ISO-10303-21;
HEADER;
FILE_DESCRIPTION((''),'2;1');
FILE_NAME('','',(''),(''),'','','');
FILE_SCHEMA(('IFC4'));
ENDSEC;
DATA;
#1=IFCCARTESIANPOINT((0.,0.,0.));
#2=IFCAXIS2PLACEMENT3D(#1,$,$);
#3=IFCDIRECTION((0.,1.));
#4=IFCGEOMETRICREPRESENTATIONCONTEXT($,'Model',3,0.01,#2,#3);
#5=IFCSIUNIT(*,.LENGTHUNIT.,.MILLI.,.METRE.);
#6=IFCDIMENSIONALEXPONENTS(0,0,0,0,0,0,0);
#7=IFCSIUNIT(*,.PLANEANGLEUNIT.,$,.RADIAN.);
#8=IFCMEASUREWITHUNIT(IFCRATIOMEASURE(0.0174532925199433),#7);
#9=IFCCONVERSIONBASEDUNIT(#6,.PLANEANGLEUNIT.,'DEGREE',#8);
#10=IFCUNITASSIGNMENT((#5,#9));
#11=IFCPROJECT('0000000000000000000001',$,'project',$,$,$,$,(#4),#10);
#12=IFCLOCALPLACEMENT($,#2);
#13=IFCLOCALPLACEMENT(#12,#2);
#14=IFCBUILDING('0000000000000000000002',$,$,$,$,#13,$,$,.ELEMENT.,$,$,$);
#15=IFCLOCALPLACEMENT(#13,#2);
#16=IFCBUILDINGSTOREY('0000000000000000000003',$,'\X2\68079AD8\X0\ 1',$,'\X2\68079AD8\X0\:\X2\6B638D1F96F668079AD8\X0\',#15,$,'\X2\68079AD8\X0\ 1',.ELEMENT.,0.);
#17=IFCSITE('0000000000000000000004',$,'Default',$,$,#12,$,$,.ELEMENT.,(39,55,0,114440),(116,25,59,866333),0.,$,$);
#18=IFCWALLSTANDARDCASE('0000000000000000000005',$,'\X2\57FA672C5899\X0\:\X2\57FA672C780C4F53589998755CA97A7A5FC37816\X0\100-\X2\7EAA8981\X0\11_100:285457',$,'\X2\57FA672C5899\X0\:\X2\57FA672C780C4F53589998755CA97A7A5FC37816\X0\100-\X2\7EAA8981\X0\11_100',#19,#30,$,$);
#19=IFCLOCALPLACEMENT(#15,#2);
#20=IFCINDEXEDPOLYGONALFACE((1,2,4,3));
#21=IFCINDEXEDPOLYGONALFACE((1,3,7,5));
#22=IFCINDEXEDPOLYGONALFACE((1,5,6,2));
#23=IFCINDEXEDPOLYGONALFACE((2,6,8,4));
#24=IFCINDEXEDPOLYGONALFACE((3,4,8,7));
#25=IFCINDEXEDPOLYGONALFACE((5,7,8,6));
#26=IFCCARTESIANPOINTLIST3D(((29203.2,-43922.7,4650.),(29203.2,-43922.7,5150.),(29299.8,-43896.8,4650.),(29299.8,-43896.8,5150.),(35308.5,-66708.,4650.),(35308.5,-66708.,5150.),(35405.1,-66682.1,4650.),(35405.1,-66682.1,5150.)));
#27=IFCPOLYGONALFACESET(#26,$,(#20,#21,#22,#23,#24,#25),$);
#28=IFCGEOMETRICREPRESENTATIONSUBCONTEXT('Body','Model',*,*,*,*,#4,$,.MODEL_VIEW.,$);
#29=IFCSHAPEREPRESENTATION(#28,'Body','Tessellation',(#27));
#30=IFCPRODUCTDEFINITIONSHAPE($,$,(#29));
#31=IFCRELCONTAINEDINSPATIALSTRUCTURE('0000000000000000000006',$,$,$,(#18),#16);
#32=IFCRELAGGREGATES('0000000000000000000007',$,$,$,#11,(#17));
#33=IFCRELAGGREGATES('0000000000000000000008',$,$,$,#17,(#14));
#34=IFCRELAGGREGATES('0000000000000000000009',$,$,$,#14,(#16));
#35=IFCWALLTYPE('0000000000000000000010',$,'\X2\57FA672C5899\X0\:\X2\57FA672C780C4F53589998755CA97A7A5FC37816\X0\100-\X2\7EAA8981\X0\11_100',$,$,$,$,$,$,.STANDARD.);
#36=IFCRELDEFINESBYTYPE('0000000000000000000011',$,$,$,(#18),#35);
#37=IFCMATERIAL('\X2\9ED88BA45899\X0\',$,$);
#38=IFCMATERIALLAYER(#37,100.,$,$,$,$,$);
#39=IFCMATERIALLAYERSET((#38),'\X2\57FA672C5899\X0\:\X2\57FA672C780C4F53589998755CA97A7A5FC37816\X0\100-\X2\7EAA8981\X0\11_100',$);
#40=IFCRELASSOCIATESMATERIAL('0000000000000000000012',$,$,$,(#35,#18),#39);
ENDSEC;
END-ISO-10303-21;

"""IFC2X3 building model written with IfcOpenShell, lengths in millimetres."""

from ifc_helpers import new_model, entity, si_unit, converted_unit, direction, frame, frame_2d, origin, place, context, subcontext, project, spatial, rectangle, extrude, material, layer, layer_set, layer_usage, type_object, element, save


model = new_model("IFC2X3")

# Units and contexts
model_context = context("Model", 3, precision=0.01, world=origin(), true_north=direction((0.0, 1.0)))
body_context = subcontext(model_context, "Body", "Model", "MODEL_VIEW")
ifc_project = project(units=[si_unit("LENGTHUNIT", "METRE", prefix="MILLI"), converted_unit("PLANEANGLEUNIT", "DEGREE", entity("IfcRatioMeasure", 0.0174532925199433), si_unit("PLANEANGLEUNIT", "RADIAN"), dimensions=[0, 0, 0, 0, 0, 0, 0])], contexts=[model_context])

# Site, building, storey
site_placement = place(None, origin())
site = spatial("IfcSite", under=ifc_project, at=site_placement, Name="Default", CompositionType="ELEMENT", RefLatitude=(39, 55, 0, 114440), RefLongitude=(116, 25, 59, 866333), RefElevation=0.0)
building_placement = place(site_placement, origin())
building = spatial("IfcBuilding", under=site, at=building_placement, CompositionType="ELEMENT")
storey_placement = place(building_placement, origin())
storey = spatial("IfcBuildingStorey", under=building, at=storey_placement, Name="标高 1", ObjectType="标高:正负零标高", LongName="标高 1", CompositionType="ELEMENT", Elevation=0.0)

# Wall
ifc_material = material(Name="默认墙")
ifc_layer_1 = layer(ifc_material, 100.0)
ifc_layer_set_1 = layer_set([ifc_layer_1], Name="基本墙:基本砌体墙页岩空心砖100-纪要11_100")
ifc_layer_usage_1 = layer_usage(ifc_layer_set_1, "AXIS2", "NEGATIVE", 50.0)
wall_type_1 = type_object("IfcWallType", Name="基本墙:基本砌体墙页岩空心砖100-纪要11_100", PredefinedType="STANDARD", material=ifc_layer_set_1)
wall_1_placement = place(building_placement, frame((29251.5, -43909.7, 4650.0), z_axis=(0.0, 0.0, 1.0), x_axis=(0.258819, -0.965926, 0.0)))
element("IfcWallStandardCase", 1, at=wall_1_placement, inside=storey, type_object=wall_type_1, material=ifc_layer_usage_1, Name="基本墙:基本砌体墙页岩空心砖100-纪要11_100:285457", ObjectType="基本墙:基本砌体墙页岩空心砖100-纪要11_100", context=body_context, shape_type="SweptSolid", body=[
    extrude(rectangle(XDim=23589.1, YDim=100.0, at=frame_2d((11794.6, 0.0), x_axis=(-1.0, 0.0))), origin(), (0.0, 0.0, 1.0), 500.0),
])

save(model, "model.ifc")
